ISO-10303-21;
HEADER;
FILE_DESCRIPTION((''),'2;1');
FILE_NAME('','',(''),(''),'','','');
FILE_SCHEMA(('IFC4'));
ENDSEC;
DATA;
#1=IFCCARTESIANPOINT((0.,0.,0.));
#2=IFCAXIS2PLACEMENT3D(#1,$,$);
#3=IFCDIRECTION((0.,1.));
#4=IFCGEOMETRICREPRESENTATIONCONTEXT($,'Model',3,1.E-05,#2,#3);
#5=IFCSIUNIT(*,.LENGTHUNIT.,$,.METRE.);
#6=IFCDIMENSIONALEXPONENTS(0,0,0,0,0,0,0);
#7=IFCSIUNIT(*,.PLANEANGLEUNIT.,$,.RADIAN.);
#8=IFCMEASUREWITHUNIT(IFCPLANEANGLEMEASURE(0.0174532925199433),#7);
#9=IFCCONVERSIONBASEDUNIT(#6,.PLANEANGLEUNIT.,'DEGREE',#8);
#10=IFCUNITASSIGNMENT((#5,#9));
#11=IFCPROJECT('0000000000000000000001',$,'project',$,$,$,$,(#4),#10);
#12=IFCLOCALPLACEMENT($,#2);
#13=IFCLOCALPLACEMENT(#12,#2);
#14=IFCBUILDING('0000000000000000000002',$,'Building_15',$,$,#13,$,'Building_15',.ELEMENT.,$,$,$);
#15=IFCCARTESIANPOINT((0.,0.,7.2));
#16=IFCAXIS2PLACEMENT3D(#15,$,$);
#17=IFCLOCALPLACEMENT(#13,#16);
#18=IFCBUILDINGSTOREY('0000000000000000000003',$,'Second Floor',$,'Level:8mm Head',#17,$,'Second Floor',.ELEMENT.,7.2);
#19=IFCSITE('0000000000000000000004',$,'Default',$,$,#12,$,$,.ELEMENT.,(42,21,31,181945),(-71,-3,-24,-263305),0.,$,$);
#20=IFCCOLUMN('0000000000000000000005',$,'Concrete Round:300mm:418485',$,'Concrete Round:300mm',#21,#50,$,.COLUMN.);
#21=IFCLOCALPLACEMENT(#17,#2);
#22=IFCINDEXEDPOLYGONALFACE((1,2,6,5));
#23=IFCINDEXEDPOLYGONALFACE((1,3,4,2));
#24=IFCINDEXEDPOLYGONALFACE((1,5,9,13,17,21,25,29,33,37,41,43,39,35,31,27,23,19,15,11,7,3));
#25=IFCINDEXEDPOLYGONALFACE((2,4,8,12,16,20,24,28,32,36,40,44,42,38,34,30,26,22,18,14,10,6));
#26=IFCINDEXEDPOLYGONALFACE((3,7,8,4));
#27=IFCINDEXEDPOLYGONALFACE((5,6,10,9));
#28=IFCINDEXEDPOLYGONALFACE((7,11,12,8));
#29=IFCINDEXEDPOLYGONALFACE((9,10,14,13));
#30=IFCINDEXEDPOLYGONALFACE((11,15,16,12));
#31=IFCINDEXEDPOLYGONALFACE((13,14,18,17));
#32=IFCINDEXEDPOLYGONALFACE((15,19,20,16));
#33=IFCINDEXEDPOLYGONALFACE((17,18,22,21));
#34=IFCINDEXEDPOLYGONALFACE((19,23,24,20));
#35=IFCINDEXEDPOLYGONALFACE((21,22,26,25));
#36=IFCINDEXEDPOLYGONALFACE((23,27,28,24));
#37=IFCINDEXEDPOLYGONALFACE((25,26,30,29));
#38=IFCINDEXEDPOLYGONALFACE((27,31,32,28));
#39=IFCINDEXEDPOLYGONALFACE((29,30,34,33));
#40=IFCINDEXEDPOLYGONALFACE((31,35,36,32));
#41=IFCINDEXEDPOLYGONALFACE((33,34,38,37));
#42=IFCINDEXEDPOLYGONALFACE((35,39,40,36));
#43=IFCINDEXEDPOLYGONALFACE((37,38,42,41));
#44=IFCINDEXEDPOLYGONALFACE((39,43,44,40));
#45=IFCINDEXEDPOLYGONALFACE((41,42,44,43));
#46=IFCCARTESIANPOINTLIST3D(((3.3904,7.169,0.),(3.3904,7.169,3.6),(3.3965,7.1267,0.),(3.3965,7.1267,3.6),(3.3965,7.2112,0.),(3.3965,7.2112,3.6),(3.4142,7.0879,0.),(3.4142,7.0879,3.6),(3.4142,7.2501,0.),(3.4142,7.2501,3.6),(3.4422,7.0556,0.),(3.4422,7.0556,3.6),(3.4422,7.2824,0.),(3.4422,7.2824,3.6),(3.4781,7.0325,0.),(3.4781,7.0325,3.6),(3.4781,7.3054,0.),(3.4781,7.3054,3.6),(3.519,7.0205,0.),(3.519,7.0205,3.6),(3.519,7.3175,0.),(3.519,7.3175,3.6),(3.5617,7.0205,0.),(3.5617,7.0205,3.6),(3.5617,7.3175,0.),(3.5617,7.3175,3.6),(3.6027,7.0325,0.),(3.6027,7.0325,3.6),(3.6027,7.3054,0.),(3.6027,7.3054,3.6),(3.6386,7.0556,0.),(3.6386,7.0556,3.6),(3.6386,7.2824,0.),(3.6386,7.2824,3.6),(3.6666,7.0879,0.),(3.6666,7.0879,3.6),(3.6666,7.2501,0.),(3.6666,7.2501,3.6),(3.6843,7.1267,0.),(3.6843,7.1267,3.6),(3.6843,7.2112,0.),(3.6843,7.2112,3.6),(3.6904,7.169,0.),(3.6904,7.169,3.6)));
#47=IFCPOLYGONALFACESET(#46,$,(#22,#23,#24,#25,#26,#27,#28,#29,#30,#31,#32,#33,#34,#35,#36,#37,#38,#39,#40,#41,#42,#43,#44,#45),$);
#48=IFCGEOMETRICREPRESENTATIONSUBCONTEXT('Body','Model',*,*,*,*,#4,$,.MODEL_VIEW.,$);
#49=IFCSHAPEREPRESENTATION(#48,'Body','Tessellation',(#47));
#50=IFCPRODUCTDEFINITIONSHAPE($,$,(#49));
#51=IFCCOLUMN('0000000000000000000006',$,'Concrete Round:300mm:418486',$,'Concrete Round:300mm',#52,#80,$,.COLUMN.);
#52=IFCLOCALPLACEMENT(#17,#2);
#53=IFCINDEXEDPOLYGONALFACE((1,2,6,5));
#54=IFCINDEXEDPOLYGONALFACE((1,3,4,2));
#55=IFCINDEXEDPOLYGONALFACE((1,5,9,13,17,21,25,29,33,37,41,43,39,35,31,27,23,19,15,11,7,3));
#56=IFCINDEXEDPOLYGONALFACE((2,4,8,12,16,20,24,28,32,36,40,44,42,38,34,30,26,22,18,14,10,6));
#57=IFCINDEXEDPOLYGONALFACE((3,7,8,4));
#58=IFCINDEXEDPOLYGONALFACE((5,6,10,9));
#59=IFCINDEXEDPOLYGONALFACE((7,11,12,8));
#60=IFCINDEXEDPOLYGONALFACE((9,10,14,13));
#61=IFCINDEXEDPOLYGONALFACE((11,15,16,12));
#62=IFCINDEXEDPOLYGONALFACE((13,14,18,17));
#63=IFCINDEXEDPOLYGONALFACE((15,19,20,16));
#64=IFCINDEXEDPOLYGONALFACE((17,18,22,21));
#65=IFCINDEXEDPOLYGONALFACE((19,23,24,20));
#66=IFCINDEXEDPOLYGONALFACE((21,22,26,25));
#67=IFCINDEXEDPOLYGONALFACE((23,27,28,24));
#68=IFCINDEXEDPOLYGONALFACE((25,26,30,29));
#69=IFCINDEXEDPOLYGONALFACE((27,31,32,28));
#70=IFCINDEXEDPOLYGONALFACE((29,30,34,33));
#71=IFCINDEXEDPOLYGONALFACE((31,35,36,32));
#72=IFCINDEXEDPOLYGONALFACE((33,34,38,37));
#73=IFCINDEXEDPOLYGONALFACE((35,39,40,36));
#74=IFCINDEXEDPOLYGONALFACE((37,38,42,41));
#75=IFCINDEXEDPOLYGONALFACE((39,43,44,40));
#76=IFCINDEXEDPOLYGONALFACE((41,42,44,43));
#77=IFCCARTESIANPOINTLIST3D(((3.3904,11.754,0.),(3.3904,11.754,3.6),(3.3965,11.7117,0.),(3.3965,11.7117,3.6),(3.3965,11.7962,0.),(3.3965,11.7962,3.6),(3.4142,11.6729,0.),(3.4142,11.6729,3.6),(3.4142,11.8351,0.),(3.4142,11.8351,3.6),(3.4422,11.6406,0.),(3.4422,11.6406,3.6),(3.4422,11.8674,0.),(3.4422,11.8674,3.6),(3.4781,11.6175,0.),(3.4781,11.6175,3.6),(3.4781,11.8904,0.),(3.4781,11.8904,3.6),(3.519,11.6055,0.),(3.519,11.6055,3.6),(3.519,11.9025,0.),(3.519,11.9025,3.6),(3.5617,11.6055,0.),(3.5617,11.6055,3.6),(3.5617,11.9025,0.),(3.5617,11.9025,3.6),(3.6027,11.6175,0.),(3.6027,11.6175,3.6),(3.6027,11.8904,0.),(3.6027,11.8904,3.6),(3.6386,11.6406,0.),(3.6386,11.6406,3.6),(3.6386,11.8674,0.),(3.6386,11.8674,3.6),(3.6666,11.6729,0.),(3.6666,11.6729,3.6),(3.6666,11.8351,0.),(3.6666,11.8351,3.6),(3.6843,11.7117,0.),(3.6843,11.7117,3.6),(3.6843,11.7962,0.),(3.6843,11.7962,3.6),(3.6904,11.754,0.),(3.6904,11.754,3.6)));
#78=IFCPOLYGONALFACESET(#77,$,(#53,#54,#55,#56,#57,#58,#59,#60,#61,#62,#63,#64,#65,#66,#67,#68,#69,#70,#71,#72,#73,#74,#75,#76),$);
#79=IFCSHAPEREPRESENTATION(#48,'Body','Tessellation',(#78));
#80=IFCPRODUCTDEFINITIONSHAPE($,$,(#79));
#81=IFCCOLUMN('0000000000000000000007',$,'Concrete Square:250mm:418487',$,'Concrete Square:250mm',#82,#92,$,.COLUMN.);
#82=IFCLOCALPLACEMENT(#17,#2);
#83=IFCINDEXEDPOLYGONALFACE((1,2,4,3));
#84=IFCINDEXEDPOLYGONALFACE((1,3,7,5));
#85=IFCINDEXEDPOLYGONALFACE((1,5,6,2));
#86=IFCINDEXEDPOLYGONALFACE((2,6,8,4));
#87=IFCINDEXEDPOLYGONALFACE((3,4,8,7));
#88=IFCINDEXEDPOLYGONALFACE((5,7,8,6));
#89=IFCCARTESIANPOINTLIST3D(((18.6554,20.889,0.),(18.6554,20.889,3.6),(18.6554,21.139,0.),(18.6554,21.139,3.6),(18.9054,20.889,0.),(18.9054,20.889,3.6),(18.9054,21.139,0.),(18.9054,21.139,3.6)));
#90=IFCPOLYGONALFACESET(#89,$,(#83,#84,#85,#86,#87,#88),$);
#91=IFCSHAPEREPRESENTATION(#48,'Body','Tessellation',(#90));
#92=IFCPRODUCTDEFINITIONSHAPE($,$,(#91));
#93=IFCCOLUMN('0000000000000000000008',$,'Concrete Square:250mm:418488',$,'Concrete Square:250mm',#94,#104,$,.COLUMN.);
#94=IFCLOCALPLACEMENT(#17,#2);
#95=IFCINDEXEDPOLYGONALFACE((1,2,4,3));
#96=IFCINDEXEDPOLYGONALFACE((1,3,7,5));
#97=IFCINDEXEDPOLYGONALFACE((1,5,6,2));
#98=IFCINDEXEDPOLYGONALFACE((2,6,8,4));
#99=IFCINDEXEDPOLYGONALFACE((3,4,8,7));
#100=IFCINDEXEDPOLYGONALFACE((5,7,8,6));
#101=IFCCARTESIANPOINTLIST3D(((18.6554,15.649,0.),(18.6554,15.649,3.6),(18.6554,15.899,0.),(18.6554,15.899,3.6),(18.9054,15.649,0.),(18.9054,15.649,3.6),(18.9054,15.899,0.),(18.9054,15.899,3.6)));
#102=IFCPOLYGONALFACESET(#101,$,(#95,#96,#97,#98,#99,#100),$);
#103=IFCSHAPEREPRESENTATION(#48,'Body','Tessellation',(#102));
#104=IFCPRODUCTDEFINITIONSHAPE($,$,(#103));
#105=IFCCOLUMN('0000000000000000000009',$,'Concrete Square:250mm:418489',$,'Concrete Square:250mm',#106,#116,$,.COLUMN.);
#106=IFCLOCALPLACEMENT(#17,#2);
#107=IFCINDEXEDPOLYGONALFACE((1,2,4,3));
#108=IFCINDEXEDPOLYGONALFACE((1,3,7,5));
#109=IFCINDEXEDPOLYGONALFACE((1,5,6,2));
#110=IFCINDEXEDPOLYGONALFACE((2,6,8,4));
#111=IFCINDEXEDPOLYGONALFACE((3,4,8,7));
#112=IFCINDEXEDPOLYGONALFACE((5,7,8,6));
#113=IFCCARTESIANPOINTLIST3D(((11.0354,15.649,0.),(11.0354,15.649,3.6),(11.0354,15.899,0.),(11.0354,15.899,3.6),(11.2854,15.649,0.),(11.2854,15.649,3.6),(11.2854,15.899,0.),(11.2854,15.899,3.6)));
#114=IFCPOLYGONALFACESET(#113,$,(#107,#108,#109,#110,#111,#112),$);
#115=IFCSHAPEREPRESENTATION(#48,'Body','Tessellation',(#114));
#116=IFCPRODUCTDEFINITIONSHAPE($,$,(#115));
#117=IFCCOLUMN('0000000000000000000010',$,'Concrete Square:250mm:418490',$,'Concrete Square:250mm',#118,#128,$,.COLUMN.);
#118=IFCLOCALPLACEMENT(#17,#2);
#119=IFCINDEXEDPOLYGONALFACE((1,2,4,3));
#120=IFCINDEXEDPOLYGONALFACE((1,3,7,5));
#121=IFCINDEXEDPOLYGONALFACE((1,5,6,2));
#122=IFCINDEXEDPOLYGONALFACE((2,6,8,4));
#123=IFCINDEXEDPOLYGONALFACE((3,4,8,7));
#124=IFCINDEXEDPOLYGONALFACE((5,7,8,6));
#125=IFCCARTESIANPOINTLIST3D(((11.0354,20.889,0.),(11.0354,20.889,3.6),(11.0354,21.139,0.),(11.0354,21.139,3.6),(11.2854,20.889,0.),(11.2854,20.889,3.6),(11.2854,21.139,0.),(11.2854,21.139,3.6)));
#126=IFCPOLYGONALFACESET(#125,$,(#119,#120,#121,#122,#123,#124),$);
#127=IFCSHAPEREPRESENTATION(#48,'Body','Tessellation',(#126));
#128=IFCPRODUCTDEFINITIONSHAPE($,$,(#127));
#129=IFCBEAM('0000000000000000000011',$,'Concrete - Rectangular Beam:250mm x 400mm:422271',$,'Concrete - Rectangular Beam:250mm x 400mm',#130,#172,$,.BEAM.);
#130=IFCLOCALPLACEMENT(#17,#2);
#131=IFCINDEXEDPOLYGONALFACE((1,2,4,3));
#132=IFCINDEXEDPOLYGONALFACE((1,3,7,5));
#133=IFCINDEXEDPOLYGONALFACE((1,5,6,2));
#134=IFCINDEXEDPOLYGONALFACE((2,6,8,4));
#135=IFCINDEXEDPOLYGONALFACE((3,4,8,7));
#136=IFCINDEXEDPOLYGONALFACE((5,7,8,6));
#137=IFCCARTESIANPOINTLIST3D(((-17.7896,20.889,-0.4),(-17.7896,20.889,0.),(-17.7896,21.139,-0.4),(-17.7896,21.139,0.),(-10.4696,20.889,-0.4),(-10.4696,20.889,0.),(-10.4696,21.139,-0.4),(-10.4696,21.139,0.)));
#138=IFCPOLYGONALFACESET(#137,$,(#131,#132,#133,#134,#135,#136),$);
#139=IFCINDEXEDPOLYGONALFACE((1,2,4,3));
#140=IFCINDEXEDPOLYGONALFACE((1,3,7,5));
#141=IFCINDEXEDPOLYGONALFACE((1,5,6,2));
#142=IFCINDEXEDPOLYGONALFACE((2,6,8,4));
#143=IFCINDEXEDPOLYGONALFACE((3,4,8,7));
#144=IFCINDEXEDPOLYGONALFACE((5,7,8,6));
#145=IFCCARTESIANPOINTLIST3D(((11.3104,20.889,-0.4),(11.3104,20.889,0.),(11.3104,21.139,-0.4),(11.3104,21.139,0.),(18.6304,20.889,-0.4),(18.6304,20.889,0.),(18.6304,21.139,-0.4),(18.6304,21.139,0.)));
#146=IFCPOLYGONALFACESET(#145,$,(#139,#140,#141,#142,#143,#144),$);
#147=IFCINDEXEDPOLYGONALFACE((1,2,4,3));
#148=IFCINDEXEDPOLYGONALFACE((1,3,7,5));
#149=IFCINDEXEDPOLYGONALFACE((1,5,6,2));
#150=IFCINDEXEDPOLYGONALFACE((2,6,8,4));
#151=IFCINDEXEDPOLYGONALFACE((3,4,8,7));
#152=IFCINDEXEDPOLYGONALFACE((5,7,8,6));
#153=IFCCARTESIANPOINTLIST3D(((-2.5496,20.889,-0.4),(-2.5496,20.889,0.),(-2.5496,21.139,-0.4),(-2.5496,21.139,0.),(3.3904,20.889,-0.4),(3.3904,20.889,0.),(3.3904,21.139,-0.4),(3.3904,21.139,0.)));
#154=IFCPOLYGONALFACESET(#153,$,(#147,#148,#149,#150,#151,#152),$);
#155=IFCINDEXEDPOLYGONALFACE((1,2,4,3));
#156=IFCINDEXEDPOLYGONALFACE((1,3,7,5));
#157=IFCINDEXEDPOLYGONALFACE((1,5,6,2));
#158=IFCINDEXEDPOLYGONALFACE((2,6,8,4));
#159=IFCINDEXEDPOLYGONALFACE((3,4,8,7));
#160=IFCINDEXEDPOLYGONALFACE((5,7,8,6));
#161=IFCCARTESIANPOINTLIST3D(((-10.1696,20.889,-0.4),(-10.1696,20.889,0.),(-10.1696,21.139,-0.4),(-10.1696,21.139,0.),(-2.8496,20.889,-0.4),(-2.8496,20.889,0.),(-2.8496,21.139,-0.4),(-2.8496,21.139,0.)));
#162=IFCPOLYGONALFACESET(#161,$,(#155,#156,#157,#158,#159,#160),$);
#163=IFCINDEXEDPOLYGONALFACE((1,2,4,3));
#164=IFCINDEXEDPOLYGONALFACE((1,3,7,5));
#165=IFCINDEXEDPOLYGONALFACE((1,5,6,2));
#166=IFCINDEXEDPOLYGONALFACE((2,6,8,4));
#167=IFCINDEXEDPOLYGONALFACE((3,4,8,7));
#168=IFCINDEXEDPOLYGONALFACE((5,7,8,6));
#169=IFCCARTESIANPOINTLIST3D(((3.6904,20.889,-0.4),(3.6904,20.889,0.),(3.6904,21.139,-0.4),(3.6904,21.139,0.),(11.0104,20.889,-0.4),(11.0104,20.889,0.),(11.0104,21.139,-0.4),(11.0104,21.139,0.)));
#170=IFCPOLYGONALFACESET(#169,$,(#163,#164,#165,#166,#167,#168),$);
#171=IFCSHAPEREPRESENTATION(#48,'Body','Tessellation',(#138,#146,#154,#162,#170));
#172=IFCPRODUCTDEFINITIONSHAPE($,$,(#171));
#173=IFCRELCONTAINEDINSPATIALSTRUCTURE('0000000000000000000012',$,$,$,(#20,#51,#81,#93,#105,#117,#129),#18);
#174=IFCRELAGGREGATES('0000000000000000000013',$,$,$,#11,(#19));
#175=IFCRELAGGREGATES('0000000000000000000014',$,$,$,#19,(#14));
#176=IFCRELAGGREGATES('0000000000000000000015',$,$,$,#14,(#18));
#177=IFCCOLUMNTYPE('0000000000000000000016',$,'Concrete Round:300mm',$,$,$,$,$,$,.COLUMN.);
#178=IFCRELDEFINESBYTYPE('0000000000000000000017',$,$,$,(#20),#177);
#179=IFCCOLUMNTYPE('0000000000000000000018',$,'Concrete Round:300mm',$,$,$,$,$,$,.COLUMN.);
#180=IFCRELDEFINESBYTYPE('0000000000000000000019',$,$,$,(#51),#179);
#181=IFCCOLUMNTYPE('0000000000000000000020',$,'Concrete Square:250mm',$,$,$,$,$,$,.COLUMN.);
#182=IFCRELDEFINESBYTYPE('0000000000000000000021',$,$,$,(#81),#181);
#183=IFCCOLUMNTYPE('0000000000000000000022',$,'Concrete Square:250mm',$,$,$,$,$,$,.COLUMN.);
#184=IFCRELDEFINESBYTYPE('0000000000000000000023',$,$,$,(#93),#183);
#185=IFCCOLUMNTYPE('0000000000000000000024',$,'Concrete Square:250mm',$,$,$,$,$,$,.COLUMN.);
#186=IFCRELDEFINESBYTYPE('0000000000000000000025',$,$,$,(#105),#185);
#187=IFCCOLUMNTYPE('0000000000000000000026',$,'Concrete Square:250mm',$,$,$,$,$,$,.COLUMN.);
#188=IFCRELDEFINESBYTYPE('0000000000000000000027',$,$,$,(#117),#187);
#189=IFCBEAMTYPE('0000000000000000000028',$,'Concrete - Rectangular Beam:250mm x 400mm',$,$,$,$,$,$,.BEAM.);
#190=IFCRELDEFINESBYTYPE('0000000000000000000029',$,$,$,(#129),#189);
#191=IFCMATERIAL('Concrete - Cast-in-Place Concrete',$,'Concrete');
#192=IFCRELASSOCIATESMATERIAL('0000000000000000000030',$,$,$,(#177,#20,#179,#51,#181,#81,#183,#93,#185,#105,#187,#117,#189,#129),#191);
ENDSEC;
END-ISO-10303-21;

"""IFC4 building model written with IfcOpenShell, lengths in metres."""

from ifc_helpers import new_model, entity, si_unit, converted_unit, direction, frame, origin, place, context, subcontext, project, spatial, arc, indexed_curve, outline, extrude, source, transform, mapped, material, type_object, type_shapes, element, save


model = new_model("IFC4")

# Units and contexts
model_context = context("Model", 3, precision=1e-05, world=origin(), true_north=direction((0.0, 1.0)))
body_context = subcontext(model_context, "Body", "Model", "MODEL_VIEW")
ifc_project = project(units=[si_unit("LENGTHUNIT", "METRE"), converted_unit("PLANEANGLEUNIT", "DEGREE", entity("IfcPlaneAngleMeasure", 0.0174532925199433), si_unit("PLANEANGLEUNIT", "RADIAN"), dimensions=[0, 0, 0, 0, 0, 0, 0])], contexts=[model_context])

# Site, building, storey
site_placement = place(None, origin())
site = spatial("IfcSite", under=ifc_project, at=site_placement, Name="Default", CompositionType="ELEMENT", RefLatitude=(42, 21, 31, 181945), RefLongitude=(-71, -3, -24, -263305), RefElevation=0.0)
building_placement = place(site_placement, origin())
building = spatial("IfcBuilding", under=site, at=building_placement, Name="Building_15", LongName="Building_15", CompositionType="ELEMENT")
storey_placement = place(building_placement, frame((0.0, 0.0, 7.2)))
storey = spatial("IfcBuildingStorey", under=building, at=storey_placement, Name="Second Floor", ObjectType="Level:8mm Head", LongName="Second Floor", CompositionType="ELEMENT", Elevation=7.2)

# Columns
ifc_material_1 = material(Name="Concrete - Cast-in-Place Concrete", Category="Concrete")
column_type_1 = type_object("IfcColumnType", Name="Concrete Round:300mm", PredefinedType="COLUMN", material=ifc_material_1)
shared_shape_1 = source(origin(), body_context, "Body", "SweptSolid", [
    extrude(outline(indexed_curve([(-0.15, 0.0), (0.0, -0.15), (0.15, 0.0), (0.0, 0.15)], segments=[arc(1, 2, 3), arc(3, 4, 1)], self_intersect=False)), frame((3.5404, 7.169, 7.2)), (0.0, 0.0, 1.0), 3.6),
])
type_shapes(column_type_1, [shared_shape_1])
column_1_placement = place(storey_placement, frame((0.0, 0.0, -7.2)))
element("IfcColumn", 1, at=column_1_placement, inside=storey, type_object=column_type_1, material=ifc_material_1, Name="Concrete Round:300mm:418485", ObjectType="Concrete Round:300mm", PredefinedType="COLUMN", context=body_context, shape_type="MappedRepresentation", body=[
    mapped(shared_shape_1, transform((0.0, 0.0, 0.0), scale=1.0)),
])
column_type_2 = type_object("IfcColumnType", Name="Concrete Round:300mm", PredefinedType="COLUMN", material=ifc_material_1)
shared_shape_2 = source(origin(), body_context, "Body", "SweptSolid", [
    extrude(outline(indexed_curve([(-0.15, 0.0), (0.0, -0.15), (0.15, 0.0), (0.0, 0.15)], segments=[arc(1, 2, 3), arc(3, 4, 1)], self_intersect=False)), frame((3.5404, 11.754, 7.2)), (0.0, 0.0, 1.0), 3.6),
])
type_shapes(column_type_2, [shared_shape_2])
column_2_placement = place(storey_placement, frame((0.0, 0.0, -7.2)))
element("IfcColumn", 2, at=column_2_placement, inside=storey, type_object=column_type_2, material=ifc_material_1, Name="Concrete Round:300mm:418486", ObjectType="Concrete Round:300mm", PredefinedType="COLUMN", context=body_context, shape_type="MappedRepresentation", body=[
    mapped(shared_shape_2, transform((0.0, 0.0, 0.0), scale=1.0)),
])
column_type_3 = type_object("IfcColumnType", Name="Concrete Square:250mm", PredefinedType="COLUMN", material=ifc_material_1)
shared_shape_3 = source(origin(), body_context, "Body", "SweptSolid", [
    extrude(outline(indexed_curve([(-0.125, -0.125), (0.125, -0.125), (0.125, 0.125), (-0.125, 0.125), (-0.125, -0.125)], self_intersect=False)), frame((18.7804, 21.014, 7.2), z_axis=(0.0, 0.0, 1.0), x_axis=(-1.0, 0.0, 0.0)), (0.0, 0.0, 1.0), 3.6),
])
type_shapes(column_type_3, [shared_shape_3])
column_3_placement = place(storey_placement, frame((0.0, 0.0, -7.2)))
element("IfcColumn", 3, at=column_3_placement, inside=storey, type_object=column_type_3, material=ifc_material_1, Name="Concrete Square:250mm:418487", ObjectType="Concrete Square:250mm", PredefinedType="COLUMN", context=body_context, shape_type="MappedRepresentation", body=[
    mapped(shared_shape_3, transform((0.0, 0.0, 0.0), scale=1.0)),
])
column_type_4 = type_object("IfcColumnType", Name="Concrete Square:250mm", PredefinedType="COLUMN", material=ifc_material_1)
shared_shape_4 = source(origin(), body_context, "Body", "SweptSolid", [
    extrude(outline(indexed_curve([(-0.125, -0.125), (0.125, -0.125), (0.125, 0.125), (-0.125, 0.125), (-0.125, -0.125)], self_intersect=False)), frame((18.7804, 15.774, 7.2), z_axis=(0.0, 0.0, 1.0), x_axis=(-1.0, 0.0, 0.0)), (0.0, 0.0, 1.0), 3.6),
])
type_shapes(column_type_4, [shared_shape_4])
column_4_placement = place(storey_placement, frame((0.0, 0.0, -7.2)))
element("IfcColumn", 4, at=column_4_placement, inside=storey, type_object=column_type_4, material=ifc_material_1, Name="Concrete Square:250mm:418488", ObjectType="Concrete Square:250mm", PredefinedType="COLUMN", context=body_context, shape_type="MappedRepresentation", body=[
    mapped(shared_shape_4, transform((0.0, 0.0, 0.0), scale=1.0)),
])
column_type_5 = type_object("IfcColumnType", Name="Concrete Square:250mm", PredefinedType="COLUMN", material=ifc_material_1)
shared_shape_5 = source(origin(), body_context, "Body", "SweptSolid", [
    extrude(outline(indexed_curve([(-0.125, -0.125), (0.125, -0.125), (0.125, 0.125), (-0.125, 0.125), (-0.125, -0.125)], self_intersect=False)), frame((11.1604, 15.774, 7.2), z_axis=(0.0, 0.0, 1.0), x_axis=(-1.0, 0.0, 0.0)), (0.0, 0.0, 1.0), 3.6),
])
type_shapes(column_type_5, [shared_shape_5])
column_5_placement = place(storey_placement, frame((0.0, 0.0, -7.2)))
element("IfcColumn", 5, at=column_5_placement, inside=storey, type_object=column_type_5, material=ifc_material_1, Name="Concrete Square:250mm:418489", ObjectType="Concrete Square:250mm", PredefinedType="COLUMN", context=body_context, shape_type="MappedRepresentation", body=[
    mapped(shared_shape_5, transform((0.0, 0.0, 0.0), scale=1.0)),
])
column_type_6 = type_object("IfcColumnType", Name="Concrete Square:250mm", PredefinedType="COLUMN", material=ifc_material_1)
shared_shape_6 = source(origin(), body_context, "Body", "SweptSolid", [
    extrude(outline(indexed_curve([(-0.125, -0.125), (0.125, -0.125), (0.125, 0.125), (-0.125, 0.125), (-0.125, -0.125)], self_intersect=False)), frame((11.1604, 21.014, 7.2), z_axis=(0.0, 0.0, 1.0), x_axis=(-1.0, 0.0, 0.0)), (0.0, 0.0, 1.0), 3.6),
])
type_shapes(column_type_6, [shared_shape_6])
column_6_placement = place(storey_placement, frame((0.0, 0.0, -7.2)))
element("IfcColumn", 6, at=column_6_placement, inside=storey, type_object=column_type_6, material=ifc_material_1, Name="Concrete Square:250mm:418490", ObjectType="Concrete Square:250mm", PredefinedType="COLUMN", context=body_context, shape_type="MappedRepresentation", body=[
    mapped(shared_shape_6, transform((0.0, 0.0, 0.0), scale=1.0)),
])

# Beam
beam_type_1 = type_object("IfcBeamType", Name="Concrete - Rectangular Beam:250mm x 400mm", PredefinedType="BEAM", material=ifc_material_1)
shared_shape_7 = source(origin(), body_context, "Body", "SweptSolid", [
    extrude(outline(indexed_curve([(-0.2, -0.125), (0.2, -0.125), (0.2, 0.125), (-0.2, 0.125), (-0.2, -0.125)], self_intersect=False)), frame((-17.7896, 21.014, 7.0), z_axis=(1.0, 0.0, 0.0), x_axis=(0.0, 0.0, -1.0)), (0.0, 0.0, 1.0), 7.32),
    extrude(outline(indexed_curve([(-0.2, -0.125), (0.2, -0.125), (0.2, 0.125), (-0.2, 0.125), (-0.2, -0.125)], self_intersect=False)), frame((11.3104, 21.014, 7.0), z_axis=(1.0, 0.0, 0.0), x_axis=(0.0, 0.0, -1.0)), (0.0, 0.0, 1.0), 7.32),
    extrude(outline(indexed_curve([(-0.2, -0.125), (0.2, -0.125), (0.2, 0.125), (-0.2, 0.125), (-0.2, -0.125)], self_intersect=False)), frame((-2.5496, 21.014, 7.0), z_axis=(1.0, 0.0, 0.0), x_axis=(0.0, 0.0, -1.0)), (0.0, 0.0, 1.0), 5.94),
    extrude(outline(indexed_curve([(-0.2, -0.125), (0.2, -0.125), (0.2, 0.125), (-0.2, 0.125), (-0.2, -0.125)], self_intersect=False)), frame((-10.1696, 21.014, 7.0), z_axis=(1.0, 0.0, 0.0), x_axis=(0.0, 0.0, -1.0)), (0.0, 0.0, 1.0), 7.32),
    extrude(outline(indexed_curve([(-0.2, -0.125), (0.2, -0.125), (0.2, 0.125), (-0.2, 0.125), (-0.2, -0.125)], self_intersect=False)), frame((3.6904, 21.014, 7.0), z_axis=(1.0, 0.0, 0.0), x_axis=(0.0, 0.0, -1.0)), (0.0, 0.0, 1.0), 7.32),
])
type_shapes(beam_type_1, [shared_shape_7])
beam_1_placement = place(storey_placement, frame((0.0, 0.0, -7.2)))
element("IfcBeam", 7, at=beam_1_placement, inside=storey, type_object=beam_type_1, material=ifc_material_1, Name="Concrete - Rectangular Beam:250mm x 400mm:422271", ObjectType="Concrete - Rectangular Beam:250mm x 400mm", PredefinedType="BEAM", context=body_context, shape_type="MappedRepresentation", body=[
    mapped(shared_shape_7, transform((0.0, 0.0, 0.0), scale=1.0)),
])

save(model, "model.ifc")
